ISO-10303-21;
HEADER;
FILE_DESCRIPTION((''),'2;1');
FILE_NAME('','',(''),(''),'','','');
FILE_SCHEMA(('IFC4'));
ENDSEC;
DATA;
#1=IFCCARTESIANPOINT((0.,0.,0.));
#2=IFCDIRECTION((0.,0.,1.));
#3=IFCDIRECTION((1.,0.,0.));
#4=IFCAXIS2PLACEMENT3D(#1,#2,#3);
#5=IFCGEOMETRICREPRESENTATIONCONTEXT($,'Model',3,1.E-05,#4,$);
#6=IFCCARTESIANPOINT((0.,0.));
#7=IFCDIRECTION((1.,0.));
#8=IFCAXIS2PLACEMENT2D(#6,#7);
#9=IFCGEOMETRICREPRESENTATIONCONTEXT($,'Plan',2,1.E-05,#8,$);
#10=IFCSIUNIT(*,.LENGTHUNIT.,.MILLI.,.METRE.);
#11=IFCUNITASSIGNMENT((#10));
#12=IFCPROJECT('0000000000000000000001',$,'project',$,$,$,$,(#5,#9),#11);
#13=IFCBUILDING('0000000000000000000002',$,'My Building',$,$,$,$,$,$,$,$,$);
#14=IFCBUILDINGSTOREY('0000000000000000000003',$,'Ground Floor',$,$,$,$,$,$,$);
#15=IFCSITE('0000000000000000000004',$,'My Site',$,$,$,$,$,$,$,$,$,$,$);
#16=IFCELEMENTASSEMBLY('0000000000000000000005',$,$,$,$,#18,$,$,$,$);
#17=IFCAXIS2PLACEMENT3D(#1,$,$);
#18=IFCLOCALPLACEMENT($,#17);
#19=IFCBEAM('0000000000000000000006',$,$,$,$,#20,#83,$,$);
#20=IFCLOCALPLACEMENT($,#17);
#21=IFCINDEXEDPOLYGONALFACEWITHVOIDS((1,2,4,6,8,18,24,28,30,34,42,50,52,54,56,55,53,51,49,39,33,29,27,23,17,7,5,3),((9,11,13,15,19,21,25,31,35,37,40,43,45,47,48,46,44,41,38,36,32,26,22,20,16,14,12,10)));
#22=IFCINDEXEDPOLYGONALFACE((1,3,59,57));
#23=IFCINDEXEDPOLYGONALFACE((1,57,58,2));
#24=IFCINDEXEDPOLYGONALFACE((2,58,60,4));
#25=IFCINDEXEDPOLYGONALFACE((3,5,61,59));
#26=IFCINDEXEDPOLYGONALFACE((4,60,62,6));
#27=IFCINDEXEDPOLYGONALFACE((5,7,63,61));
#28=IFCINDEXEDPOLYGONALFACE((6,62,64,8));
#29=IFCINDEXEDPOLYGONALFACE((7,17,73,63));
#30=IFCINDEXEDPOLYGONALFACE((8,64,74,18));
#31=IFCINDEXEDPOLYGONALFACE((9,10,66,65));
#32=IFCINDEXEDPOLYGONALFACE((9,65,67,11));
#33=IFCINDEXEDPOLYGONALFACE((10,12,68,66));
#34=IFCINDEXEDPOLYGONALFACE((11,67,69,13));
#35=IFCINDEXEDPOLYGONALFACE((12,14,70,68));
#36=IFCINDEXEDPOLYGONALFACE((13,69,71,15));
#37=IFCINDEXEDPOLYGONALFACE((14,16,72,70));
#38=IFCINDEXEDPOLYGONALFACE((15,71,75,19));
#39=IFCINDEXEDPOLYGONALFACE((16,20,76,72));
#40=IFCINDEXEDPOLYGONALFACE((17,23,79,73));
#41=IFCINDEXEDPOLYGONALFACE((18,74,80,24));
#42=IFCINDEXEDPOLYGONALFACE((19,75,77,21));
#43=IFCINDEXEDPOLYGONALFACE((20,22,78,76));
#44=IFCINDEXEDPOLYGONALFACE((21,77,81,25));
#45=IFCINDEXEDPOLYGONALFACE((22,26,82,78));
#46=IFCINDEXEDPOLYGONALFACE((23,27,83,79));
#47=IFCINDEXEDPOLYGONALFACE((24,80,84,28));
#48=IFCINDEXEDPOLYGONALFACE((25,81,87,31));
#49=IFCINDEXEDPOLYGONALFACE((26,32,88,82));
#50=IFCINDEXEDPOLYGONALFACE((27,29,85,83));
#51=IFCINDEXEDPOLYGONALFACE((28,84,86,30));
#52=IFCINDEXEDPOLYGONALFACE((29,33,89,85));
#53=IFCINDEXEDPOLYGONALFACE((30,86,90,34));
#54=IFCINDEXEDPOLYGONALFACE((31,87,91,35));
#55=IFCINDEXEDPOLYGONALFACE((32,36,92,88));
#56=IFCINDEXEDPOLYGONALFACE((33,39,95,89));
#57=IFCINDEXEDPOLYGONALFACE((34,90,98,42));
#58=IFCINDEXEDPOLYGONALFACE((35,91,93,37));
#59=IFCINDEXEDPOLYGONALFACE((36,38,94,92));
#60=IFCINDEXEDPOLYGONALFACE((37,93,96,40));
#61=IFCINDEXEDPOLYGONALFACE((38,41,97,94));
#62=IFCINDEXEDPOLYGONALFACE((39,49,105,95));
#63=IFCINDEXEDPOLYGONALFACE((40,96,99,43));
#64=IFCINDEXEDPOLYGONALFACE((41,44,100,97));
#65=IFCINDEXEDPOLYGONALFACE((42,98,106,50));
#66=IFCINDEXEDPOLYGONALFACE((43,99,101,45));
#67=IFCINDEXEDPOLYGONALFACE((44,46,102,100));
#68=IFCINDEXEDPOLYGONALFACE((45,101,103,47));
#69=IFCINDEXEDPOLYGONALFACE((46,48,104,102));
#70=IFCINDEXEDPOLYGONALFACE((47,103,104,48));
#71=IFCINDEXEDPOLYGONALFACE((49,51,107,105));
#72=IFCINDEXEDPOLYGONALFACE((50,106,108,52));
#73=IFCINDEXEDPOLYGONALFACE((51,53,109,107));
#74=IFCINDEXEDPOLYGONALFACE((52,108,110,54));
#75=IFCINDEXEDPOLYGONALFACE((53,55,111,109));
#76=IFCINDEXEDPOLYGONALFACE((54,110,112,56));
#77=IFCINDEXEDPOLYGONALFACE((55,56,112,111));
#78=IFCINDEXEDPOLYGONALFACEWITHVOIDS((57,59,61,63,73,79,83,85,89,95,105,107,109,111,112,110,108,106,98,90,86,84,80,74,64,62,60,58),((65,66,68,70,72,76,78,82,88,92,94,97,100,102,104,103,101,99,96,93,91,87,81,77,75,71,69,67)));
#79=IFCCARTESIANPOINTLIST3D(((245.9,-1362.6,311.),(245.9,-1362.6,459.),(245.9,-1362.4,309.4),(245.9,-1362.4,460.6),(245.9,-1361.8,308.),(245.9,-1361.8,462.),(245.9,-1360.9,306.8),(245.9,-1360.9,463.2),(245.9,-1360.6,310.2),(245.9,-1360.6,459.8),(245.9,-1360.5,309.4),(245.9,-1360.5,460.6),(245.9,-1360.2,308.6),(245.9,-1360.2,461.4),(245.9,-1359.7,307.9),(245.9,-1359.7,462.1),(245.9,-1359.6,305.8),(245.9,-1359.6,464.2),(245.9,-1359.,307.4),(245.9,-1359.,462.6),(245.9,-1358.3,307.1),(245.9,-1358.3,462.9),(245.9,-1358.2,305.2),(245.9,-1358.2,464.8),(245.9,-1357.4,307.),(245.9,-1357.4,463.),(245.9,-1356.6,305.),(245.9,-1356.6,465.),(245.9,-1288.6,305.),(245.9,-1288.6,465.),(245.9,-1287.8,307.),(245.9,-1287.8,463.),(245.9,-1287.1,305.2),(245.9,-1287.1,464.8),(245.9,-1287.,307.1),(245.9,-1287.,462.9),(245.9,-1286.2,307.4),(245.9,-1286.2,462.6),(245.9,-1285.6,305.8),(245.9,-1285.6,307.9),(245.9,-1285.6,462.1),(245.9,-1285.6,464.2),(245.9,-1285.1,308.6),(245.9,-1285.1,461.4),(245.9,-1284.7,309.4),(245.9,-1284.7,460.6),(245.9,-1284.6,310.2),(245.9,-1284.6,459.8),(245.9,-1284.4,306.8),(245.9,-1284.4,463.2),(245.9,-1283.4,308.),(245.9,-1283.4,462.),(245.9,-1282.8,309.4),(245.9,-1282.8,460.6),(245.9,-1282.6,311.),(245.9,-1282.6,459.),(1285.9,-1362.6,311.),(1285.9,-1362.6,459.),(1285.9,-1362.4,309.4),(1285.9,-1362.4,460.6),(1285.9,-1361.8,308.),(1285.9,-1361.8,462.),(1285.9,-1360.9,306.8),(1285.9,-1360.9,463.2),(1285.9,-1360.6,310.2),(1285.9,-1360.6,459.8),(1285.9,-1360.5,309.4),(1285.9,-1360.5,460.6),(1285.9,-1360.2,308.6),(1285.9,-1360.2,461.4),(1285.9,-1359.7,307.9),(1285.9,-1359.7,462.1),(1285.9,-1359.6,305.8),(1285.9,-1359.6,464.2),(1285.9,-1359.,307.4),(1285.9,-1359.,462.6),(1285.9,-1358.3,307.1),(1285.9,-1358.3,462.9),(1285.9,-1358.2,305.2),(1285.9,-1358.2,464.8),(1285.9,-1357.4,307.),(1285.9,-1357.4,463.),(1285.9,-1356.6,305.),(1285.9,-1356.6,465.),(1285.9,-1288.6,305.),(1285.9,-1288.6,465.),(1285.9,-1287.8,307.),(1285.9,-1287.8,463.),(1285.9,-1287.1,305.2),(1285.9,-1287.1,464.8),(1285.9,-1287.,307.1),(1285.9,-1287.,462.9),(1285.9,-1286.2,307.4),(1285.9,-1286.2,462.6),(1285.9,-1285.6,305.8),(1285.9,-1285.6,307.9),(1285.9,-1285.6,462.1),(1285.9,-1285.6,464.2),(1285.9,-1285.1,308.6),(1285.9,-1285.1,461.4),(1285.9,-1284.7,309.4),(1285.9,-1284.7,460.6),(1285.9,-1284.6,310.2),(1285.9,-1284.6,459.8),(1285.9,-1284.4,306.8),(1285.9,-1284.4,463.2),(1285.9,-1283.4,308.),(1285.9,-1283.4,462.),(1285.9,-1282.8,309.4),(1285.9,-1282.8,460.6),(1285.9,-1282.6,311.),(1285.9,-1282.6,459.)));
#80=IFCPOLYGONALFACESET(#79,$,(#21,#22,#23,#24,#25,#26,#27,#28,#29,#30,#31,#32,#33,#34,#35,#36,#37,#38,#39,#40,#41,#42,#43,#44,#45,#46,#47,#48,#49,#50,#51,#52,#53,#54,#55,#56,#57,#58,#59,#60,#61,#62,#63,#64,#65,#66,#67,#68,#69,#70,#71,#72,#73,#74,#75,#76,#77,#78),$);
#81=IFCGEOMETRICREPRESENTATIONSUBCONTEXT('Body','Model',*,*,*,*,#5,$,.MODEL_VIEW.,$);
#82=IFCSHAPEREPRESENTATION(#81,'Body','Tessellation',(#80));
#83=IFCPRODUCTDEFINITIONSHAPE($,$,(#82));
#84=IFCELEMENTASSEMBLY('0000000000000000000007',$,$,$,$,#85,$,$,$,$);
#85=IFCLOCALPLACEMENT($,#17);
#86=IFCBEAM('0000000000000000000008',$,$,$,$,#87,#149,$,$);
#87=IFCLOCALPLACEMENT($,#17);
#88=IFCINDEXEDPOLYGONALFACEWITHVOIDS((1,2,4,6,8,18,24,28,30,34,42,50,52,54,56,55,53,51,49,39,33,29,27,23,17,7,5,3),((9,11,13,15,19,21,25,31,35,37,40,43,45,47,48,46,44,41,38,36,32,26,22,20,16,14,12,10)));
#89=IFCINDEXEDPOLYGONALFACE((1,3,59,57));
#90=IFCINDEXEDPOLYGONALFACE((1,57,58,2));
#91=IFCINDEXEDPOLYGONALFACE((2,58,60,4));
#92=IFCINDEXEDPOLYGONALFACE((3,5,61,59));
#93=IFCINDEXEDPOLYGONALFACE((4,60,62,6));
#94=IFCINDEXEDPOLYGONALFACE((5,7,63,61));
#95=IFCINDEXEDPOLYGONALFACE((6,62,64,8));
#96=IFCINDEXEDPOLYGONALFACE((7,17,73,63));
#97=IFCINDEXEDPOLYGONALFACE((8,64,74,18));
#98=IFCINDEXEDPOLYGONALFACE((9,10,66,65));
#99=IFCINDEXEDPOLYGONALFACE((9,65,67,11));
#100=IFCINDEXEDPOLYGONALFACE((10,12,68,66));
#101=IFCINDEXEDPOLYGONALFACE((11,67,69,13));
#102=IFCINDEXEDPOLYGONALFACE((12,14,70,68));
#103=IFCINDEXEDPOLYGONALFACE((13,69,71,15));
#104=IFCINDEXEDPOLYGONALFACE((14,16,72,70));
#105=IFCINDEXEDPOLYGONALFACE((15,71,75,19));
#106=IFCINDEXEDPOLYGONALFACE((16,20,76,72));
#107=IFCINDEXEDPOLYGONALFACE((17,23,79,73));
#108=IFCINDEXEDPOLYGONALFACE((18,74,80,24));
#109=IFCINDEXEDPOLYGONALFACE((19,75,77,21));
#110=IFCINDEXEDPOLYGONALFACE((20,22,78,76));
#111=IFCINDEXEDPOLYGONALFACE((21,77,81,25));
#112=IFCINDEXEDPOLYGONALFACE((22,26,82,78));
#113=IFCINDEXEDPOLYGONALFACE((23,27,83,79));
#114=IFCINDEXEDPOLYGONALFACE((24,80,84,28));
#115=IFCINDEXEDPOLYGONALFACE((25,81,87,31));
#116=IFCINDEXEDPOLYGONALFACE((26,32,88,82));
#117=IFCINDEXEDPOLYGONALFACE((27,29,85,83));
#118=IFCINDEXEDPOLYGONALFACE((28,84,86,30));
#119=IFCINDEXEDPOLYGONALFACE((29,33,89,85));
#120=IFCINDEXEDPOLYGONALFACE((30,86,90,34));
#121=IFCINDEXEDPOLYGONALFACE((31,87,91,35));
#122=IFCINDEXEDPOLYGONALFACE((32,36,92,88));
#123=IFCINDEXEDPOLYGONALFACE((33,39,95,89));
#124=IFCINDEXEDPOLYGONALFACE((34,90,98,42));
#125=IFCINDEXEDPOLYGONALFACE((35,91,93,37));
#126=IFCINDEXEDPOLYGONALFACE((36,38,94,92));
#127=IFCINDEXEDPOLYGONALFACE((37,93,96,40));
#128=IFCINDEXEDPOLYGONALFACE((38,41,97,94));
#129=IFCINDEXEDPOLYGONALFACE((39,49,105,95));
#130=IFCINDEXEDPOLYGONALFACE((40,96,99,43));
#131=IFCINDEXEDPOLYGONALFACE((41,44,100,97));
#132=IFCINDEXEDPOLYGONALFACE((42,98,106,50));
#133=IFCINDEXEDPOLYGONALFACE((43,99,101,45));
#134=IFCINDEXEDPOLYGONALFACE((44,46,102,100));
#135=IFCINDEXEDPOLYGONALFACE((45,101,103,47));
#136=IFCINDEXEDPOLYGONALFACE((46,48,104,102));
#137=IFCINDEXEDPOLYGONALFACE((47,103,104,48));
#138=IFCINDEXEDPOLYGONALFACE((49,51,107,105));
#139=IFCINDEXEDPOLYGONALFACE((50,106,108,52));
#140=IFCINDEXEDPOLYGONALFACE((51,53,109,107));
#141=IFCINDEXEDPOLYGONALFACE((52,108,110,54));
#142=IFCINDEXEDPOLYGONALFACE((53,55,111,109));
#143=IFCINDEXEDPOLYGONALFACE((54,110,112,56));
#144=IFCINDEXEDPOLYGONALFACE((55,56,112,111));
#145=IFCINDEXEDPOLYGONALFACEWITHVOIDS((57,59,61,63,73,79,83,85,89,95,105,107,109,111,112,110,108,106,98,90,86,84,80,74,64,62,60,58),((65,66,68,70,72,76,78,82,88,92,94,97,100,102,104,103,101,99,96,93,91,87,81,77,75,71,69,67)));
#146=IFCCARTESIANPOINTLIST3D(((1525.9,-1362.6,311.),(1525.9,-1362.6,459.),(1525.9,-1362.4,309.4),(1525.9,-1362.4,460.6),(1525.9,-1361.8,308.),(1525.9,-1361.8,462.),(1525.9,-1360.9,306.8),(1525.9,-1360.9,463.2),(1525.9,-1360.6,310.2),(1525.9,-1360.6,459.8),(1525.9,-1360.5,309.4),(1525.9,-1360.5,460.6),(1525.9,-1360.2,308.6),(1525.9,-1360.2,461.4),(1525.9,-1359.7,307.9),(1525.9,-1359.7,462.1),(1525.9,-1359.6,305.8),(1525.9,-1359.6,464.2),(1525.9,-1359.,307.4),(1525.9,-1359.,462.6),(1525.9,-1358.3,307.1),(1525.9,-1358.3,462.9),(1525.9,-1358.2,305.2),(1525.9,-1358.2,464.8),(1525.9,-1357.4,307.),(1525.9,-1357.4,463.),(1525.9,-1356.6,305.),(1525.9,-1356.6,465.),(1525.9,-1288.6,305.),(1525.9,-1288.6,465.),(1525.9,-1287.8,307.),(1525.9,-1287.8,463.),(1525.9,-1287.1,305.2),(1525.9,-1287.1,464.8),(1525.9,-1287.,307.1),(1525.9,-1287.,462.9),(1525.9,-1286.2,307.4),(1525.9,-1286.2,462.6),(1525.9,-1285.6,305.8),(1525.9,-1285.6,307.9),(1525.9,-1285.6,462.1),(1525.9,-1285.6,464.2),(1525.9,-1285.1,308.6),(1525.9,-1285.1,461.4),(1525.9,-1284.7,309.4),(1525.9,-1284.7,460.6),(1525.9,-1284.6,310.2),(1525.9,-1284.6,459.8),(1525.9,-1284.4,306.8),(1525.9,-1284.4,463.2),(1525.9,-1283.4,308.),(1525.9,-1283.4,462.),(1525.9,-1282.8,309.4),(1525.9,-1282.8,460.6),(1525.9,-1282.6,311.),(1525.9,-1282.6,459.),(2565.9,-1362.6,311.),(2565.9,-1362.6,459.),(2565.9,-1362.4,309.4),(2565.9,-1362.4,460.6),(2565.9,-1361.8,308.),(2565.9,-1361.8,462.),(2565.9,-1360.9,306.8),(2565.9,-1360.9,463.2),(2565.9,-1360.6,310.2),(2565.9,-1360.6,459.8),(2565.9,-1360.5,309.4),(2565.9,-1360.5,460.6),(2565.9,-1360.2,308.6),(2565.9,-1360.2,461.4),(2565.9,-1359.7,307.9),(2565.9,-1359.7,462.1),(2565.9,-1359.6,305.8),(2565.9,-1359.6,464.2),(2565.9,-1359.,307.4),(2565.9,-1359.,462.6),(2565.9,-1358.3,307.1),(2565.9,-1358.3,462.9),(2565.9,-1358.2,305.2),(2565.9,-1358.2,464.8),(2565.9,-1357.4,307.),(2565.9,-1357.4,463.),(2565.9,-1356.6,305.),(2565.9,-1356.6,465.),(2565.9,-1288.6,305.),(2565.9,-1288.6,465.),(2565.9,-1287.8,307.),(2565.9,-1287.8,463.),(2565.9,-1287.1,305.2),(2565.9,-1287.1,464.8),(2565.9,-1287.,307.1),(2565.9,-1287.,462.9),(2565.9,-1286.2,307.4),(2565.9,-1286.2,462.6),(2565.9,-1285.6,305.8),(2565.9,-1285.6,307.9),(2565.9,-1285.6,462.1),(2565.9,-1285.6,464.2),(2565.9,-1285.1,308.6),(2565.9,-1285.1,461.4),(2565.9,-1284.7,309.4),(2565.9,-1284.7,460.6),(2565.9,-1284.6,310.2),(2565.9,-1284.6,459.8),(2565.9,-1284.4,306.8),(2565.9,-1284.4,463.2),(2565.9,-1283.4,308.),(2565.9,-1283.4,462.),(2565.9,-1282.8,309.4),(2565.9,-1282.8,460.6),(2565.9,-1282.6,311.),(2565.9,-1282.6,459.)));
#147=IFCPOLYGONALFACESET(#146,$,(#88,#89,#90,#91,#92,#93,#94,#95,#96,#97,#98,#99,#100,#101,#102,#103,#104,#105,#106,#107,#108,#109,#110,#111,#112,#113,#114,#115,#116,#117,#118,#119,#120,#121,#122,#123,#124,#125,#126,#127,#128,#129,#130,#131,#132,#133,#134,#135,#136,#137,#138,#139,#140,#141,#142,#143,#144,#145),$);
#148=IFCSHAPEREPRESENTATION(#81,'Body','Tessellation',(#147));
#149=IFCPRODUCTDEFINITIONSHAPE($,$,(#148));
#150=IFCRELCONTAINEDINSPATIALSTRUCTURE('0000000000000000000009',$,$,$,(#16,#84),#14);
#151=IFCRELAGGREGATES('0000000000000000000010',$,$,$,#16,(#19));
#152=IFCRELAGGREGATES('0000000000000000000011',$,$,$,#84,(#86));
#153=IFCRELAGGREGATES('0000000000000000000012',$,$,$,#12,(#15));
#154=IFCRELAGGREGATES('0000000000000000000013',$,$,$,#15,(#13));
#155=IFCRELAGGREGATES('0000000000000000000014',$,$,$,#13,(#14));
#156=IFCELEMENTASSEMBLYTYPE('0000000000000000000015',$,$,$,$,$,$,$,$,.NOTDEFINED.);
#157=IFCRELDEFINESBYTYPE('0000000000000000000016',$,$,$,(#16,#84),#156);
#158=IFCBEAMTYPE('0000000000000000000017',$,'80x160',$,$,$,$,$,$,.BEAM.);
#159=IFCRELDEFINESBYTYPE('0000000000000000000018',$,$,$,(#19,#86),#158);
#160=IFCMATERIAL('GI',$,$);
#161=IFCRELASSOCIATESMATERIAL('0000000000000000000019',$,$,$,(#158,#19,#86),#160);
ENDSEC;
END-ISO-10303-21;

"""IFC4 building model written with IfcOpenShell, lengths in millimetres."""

from ifc_helpers import new_model, si_unit, frame, origin_with_axes, origin_2d_with_axis, place, context, subcontext, project, spatial, hollow_rectangle, extrude, material, material_profile, profile_set, profile_usage, type_object, element, aggregate, save


model = new_model("IFC4")

# Units and contexts
model_context = context("Model", 3, precision=1e-05, world=origin_with_axes())
plan_context = context("Plan", 2, precision=1e-05, world=origin_2d_with_axis())
body_context = subcontext(model_context, "Body", "Model", "MODEL_VIEW")
ifc_project = project(units=[si_unit("LENGTHUNIT", "METRE", prefix="MILLI")], contexts=[model_context, plan_context])

# Site, building, storey
site = spatial("IfcSite", under=ifc_project, Name="My Site")
building = spatial("IfcBuilding", under=site, Name="My Building")
storey = spatial("IfcBuildingStorey", under=building, Name="Ground Floor")

# Shared definitions
ifc_material_1 = material(Name="GI")

# Element assemblies, beams
element_assembly_type_1 = type_object("IfcElementAssemblyType", PredefinedType="NOTDEFINED")
assembly_1_placement = place(None, frame((165.9, -1322.6, 385.0), z_axis=(1.0, 0.0, 0.0), x_axis=(0.0, 1.0, 0.0)))
assembly_1 = element("IfcElementAssembly", 1, at=assembly_1_placement, inside=storey, type_object=element_assembly_type_1)
ifc_material_profile_1 = material_profile(ifc_material_1, hollow_rectangle(XDim=80.0, YDim=160.0, WallThickness=2.0, InnerFilletRadius=3.2, OuterFilletRadius=6.0))
ifc_profile_set_1 = profile_set([ifc_material_profile_1], Name="80x160 GI Rectangular Hollow")
ifc_profile_usage_1 = profile_usage(ifc_profile_set_1)
beam_type = type_object("IfcBeamType", Name="80x160", PredefinedType="BEAM", material=ifc_profile_set_1)
beam_1_placement = place(assembly_1_placement, frame((0.0, 0.0, 80.0), z_axis=(0.0, 0.0, 1.0), x_axis=(1.0, 0.0, 0.0)))
beam_1 = element("IfcBeam", 2, at=beam_1_placement, type_object=beam_type, material=ifc_profile_usage_1, context=body_context, shape_type="SweptSolid", body=[
    extrude(hollow_rectangle(XDim=80.0, YDim=160.0, WallThickness=2.0, InnerFilletRadius=3.2, OuterFilletRadius=6.0), origin_with_axes(), (0.0, 0.0, 1.0), 1040.0),
])
aggregate(assembly_1, [beam_1])
assembly_2_placement = place(None, frame((1445.9, -1322.6, 385.0), z_axis=(1.0, 0.0, 0.0), x_axis=(0.0, 1.0, 0.0)))
assembly_2 = element("IfcElementAssembly", 3, at=assembly_2_placement, inside=storey, type_object=element_assembly_type_1)
ifc_profile_usage_2 = profile_usage(ifc_profile_set_1)
beam_2_placement = place(assembly_2_placement, frame((0.0, 0.0, 80.0), z_axis=(0.0, 0.0, 1.0), x_axis=(1.0, 0.0, 0.0)))
beam_2 = element("IfcBeam", 4, at=beam_2_placement, type_object=beam_type, material=ifc_profile_usage_2, context=body_context, shape_type="SweptSolid", body=[
    extrude(hollow_rectangle(XDim=80.0, YDim=160.0, WallThickness=2.0, InnerFilletRadius=3.2, OuterFilletRadius=6.0), origin_with_axes(), (0.0, 0.0, 1.0), 1040.0),
])
aggregate(assembly_2, [beam_2])

save(model, "model.ifc")
